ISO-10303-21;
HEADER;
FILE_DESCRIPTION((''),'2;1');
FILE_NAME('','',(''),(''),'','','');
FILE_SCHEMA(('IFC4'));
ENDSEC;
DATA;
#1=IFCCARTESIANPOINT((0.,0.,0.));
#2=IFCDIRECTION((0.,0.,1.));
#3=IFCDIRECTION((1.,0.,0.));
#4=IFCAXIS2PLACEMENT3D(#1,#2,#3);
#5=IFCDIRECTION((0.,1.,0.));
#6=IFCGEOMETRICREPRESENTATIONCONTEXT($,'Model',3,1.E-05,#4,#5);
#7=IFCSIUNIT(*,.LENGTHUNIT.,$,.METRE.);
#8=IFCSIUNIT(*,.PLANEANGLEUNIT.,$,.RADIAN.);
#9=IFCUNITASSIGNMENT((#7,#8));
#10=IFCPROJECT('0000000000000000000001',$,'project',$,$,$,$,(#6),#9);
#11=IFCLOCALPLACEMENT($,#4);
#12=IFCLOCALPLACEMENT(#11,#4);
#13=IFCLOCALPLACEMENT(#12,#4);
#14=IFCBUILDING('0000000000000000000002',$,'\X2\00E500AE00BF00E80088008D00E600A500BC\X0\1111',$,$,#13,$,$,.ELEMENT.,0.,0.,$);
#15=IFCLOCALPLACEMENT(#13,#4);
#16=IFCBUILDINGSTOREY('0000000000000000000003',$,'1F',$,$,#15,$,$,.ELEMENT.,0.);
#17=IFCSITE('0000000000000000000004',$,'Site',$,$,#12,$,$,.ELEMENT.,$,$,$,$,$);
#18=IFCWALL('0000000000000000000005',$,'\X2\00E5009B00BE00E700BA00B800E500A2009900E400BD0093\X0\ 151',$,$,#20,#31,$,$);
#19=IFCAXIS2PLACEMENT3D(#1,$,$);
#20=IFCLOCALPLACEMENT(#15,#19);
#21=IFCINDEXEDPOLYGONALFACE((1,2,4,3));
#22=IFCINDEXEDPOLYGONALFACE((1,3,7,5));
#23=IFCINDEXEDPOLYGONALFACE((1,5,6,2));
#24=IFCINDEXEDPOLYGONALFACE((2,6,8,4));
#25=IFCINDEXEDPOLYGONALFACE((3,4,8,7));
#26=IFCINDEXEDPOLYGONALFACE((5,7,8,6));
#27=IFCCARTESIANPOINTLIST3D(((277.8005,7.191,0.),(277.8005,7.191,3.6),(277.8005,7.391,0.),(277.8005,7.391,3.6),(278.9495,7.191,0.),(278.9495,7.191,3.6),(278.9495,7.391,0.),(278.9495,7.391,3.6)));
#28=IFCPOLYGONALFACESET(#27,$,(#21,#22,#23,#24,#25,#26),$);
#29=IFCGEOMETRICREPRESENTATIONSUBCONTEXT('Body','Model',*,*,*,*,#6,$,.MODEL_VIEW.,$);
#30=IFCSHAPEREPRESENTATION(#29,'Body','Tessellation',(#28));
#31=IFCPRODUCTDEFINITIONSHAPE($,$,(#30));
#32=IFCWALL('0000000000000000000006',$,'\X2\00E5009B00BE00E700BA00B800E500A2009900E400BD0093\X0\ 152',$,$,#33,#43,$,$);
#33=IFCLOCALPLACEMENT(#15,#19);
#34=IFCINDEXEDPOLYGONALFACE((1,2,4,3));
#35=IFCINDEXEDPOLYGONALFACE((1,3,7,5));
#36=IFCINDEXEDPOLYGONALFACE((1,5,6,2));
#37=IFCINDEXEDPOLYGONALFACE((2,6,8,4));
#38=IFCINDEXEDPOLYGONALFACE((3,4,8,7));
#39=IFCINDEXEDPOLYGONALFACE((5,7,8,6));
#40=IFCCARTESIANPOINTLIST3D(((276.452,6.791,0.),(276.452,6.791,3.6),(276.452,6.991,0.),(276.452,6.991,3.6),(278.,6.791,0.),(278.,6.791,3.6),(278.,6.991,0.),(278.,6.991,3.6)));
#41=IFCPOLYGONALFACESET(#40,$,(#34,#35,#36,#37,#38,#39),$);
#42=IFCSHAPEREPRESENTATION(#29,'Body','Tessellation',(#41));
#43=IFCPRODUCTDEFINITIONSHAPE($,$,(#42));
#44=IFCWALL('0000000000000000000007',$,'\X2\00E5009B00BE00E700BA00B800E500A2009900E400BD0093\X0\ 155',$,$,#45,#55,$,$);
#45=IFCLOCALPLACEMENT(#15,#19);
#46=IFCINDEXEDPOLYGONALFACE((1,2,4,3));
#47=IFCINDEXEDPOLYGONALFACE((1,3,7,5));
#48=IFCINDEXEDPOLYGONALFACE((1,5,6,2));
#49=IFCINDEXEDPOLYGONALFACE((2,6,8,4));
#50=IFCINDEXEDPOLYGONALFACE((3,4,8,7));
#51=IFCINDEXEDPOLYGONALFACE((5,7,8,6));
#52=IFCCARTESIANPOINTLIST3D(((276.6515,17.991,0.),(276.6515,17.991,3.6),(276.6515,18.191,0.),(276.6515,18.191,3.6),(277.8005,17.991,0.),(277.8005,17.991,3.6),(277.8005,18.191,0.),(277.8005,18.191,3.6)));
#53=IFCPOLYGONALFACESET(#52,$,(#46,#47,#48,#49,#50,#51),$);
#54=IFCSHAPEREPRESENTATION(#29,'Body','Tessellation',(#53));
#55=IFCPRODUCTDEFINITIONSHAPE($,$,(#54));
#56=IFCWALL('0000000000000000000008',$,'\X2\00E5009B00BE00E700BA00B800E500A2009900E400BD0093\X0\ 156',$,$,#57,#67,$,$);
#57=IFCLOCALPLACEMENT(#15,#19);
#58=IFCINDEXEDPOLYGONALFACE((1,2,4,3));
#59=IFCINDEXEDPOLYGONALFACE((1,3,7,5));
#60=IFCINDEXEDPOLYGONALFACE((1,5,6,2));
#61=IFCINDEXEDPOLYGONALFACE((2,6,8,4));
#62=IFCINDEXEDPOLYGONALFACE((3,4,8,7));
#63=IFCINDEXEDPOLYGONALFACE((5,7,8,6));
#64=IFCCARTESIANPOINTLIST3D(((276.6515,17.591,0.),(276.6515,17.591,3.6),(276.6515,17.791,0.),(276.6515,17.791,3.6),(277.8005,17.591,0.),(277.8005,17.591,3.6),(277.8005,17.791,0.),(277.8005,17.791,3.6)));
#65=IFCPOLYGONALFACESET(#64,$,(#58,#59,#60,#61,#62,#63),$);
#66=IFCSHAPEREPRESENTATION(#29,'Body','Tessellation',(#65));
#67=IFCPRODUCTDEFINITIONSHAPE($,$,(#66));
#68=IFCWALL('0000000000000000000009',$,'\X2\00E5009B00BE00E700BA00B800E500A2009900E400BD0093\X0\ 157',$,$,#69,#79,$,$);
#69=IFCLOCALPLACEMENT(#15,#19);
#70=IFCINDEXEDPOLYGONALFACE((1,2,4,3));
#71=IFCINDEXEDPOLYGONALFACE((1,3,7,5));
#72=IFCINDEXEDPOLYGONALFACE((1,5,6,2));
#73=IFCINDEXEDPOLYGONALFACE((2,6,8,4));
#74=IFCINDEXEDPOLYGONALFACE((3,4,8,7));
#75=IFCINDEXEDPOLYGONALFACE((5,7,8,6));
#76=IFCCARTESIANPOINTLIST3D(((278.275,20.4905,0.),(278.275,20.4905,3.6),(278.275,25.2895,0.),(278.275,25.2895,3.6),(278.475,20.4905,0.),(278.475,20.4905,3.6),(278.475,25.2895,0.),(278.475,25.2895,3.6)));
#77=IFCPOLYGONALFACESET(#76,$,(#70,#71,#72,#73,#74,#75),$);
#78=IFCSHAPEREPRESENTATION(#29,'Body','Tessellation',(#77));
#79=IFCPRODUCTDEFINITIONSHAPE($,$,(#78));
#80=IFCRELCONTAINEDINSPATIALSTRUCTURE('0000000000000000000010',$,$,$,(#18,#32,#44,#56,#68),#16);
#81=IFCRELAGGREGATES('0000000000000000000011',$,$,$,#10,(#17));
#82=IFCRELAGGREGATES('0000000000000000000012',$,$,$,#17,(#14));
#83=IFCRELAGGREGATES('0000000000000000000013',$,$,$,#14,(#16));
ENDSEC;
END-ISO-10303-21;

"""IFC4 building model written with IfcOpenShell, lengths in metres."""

from ifc_helpers import new_model, si_unit, direction, frame, frame_2d, origin_with_axes, place, context, subcontext, project, spatial, rectangle, extrude, element, save


model = new_model("IFC4")

# Units and contexts
model_context = context("Model", 3, precision=1e-05, world=origin_with_axes(), true_north=direction((0.0, 1.0, 0.0)))
body_context = subcontext(model_context, "Body", "Model", "MODEL_VIEW")
ifc_project = project(units=[si_unit("LENGTHUNIT", "METRE"), si_unit("PLANEANGLEUNIT", "RADIAN")], contexts=[model_context])

# Site, building, storey
placement = place(None, origin_with_axes())
site_placement = place(placement, origin_with_axes())
site = spatial("IfcSite", under=ifc_project, at=site_placement, Name="Site", CompositionType="ELEMENT")
building_placement = place(site_placement, origin_with_axes())
building = spatial("IfcBuilding", under=site, at=building_placement, Name="å®¿è\u0088\u008dæ¥¼1111", CompositionType="ELEMENT", ElevationOfRefHeight=0.0, ElevationOfTerrain=0.0)
storey_placement = place(building_placement, origin_with_axes())
storey = spatial("IfcBuildingStorey", under=building, at=storey_placement, Name="1F", CompositionType="ELEMENT", Elevation=0.0)

# Walls
wall_1_placement = place(storey_placement, frame((278.375, 7.291, 0.0), z_axis=(0.0, 0.0, 1.0), x_axis=(-1.0, 0.0, 0.0)))
element("IfcWall", 1, at=wall_1_placement, inside=storey, Name="å\u009b¾çº¸å¢\u0099ä½\u0093 151", context=body_context, shape_type="SweptSolid", body=[
    extrude(rectangle(XDim=1.149, YDim=0.2, at=frame_2d((0.0, 0.0), x_axis=(1.0, 0.0, 0.0))), frame((0.0, 0.0, 0.0), z_axis=(0.0, 0.0, 1.0)), (0.0, 0.0, 1.0), 3.6),
])
wall_2_placement = place(storey_placement, frame((277.226, 6.891, 0.0), z_axis=(0.0, 0.0, 1.0), x_axis=(1.0, 0.0, 0.0)))
element("IfcWall", 2, at=wall_2_placement, inside=storey, Name="å\u009b¾çº¸å¢\u0099ä½\u0093 152", context=body_context, shape_type="SweptSolid", body=[
    extrude(rectangle(XDim=1.548, YDim=0.2, at=frame_2d((0.0, 0.0), x_axis=(1.0, 0.0, 0.0))), frame((0.0, 0.0, 0.0), z_axis=(0.0, 0.0, 1.0)), (0.0, 0.0, 1.0), 3.6),
])
for number, where, z_axis, x_axis, name in (
    (3, (277.226, 18.091, 0.0), (0.0, 0.0, 1.0), (1.0, 0.0, 0.0), "å\u009b¾çº¸å¢\u0099ä½\u0093 155"),
    (4, (277.226, 17.691, 0.0), (0.0, 0.0, 1.0), (1.0, 0.0, 0.0), "å\u009b¾çº¸å¢\u0099ä½\u0093 156"),
):
    element("IfcWall", number, at=place(storey_placement, frame(where, z_axis=z_axis, x_axis=x_axis)), inside=storey, Name=name, context=body_context, shape_type="SweptSolid", body=[
        extrude(rectangle(XDim=1.149, YDim=0.2, at=frame_2d((0.0, 0.0), x_axis=(1.0, 0.0, 0.0))), frame((0.0, 0.0, 0.0), z_axis=(0.0, 0.0, 1.0)), (0.0, 0.0, 1.0), 3.6),
    ])
wall_3_placement = place(storey_placement, frame((278.375, 22.89, 0.0), z_axis=(0.0, 0.0, 1.0), x_axis=(0.0, -1.0, 0.0)))
element("IfcWall", 5, at=wall_3_placement, inside=storey, Name="å\u009b¾çº¸å¢\u0099ä½\u0093 157", context=body_context, shape_type="SweptSolid", body=[
    extrude(rectangle(XDim=4.799, YDim=0.2, at=frame_2d((0.0, 0.0), x_axis=(1.0, 0.0, 0.0))), frame((0.0, 0.0, 0.0), z_axis=(0.0, 0.0, 1.0)), (0.0, 0.0, 1.0), 3.6),
])

save(model, "model.ifc")
